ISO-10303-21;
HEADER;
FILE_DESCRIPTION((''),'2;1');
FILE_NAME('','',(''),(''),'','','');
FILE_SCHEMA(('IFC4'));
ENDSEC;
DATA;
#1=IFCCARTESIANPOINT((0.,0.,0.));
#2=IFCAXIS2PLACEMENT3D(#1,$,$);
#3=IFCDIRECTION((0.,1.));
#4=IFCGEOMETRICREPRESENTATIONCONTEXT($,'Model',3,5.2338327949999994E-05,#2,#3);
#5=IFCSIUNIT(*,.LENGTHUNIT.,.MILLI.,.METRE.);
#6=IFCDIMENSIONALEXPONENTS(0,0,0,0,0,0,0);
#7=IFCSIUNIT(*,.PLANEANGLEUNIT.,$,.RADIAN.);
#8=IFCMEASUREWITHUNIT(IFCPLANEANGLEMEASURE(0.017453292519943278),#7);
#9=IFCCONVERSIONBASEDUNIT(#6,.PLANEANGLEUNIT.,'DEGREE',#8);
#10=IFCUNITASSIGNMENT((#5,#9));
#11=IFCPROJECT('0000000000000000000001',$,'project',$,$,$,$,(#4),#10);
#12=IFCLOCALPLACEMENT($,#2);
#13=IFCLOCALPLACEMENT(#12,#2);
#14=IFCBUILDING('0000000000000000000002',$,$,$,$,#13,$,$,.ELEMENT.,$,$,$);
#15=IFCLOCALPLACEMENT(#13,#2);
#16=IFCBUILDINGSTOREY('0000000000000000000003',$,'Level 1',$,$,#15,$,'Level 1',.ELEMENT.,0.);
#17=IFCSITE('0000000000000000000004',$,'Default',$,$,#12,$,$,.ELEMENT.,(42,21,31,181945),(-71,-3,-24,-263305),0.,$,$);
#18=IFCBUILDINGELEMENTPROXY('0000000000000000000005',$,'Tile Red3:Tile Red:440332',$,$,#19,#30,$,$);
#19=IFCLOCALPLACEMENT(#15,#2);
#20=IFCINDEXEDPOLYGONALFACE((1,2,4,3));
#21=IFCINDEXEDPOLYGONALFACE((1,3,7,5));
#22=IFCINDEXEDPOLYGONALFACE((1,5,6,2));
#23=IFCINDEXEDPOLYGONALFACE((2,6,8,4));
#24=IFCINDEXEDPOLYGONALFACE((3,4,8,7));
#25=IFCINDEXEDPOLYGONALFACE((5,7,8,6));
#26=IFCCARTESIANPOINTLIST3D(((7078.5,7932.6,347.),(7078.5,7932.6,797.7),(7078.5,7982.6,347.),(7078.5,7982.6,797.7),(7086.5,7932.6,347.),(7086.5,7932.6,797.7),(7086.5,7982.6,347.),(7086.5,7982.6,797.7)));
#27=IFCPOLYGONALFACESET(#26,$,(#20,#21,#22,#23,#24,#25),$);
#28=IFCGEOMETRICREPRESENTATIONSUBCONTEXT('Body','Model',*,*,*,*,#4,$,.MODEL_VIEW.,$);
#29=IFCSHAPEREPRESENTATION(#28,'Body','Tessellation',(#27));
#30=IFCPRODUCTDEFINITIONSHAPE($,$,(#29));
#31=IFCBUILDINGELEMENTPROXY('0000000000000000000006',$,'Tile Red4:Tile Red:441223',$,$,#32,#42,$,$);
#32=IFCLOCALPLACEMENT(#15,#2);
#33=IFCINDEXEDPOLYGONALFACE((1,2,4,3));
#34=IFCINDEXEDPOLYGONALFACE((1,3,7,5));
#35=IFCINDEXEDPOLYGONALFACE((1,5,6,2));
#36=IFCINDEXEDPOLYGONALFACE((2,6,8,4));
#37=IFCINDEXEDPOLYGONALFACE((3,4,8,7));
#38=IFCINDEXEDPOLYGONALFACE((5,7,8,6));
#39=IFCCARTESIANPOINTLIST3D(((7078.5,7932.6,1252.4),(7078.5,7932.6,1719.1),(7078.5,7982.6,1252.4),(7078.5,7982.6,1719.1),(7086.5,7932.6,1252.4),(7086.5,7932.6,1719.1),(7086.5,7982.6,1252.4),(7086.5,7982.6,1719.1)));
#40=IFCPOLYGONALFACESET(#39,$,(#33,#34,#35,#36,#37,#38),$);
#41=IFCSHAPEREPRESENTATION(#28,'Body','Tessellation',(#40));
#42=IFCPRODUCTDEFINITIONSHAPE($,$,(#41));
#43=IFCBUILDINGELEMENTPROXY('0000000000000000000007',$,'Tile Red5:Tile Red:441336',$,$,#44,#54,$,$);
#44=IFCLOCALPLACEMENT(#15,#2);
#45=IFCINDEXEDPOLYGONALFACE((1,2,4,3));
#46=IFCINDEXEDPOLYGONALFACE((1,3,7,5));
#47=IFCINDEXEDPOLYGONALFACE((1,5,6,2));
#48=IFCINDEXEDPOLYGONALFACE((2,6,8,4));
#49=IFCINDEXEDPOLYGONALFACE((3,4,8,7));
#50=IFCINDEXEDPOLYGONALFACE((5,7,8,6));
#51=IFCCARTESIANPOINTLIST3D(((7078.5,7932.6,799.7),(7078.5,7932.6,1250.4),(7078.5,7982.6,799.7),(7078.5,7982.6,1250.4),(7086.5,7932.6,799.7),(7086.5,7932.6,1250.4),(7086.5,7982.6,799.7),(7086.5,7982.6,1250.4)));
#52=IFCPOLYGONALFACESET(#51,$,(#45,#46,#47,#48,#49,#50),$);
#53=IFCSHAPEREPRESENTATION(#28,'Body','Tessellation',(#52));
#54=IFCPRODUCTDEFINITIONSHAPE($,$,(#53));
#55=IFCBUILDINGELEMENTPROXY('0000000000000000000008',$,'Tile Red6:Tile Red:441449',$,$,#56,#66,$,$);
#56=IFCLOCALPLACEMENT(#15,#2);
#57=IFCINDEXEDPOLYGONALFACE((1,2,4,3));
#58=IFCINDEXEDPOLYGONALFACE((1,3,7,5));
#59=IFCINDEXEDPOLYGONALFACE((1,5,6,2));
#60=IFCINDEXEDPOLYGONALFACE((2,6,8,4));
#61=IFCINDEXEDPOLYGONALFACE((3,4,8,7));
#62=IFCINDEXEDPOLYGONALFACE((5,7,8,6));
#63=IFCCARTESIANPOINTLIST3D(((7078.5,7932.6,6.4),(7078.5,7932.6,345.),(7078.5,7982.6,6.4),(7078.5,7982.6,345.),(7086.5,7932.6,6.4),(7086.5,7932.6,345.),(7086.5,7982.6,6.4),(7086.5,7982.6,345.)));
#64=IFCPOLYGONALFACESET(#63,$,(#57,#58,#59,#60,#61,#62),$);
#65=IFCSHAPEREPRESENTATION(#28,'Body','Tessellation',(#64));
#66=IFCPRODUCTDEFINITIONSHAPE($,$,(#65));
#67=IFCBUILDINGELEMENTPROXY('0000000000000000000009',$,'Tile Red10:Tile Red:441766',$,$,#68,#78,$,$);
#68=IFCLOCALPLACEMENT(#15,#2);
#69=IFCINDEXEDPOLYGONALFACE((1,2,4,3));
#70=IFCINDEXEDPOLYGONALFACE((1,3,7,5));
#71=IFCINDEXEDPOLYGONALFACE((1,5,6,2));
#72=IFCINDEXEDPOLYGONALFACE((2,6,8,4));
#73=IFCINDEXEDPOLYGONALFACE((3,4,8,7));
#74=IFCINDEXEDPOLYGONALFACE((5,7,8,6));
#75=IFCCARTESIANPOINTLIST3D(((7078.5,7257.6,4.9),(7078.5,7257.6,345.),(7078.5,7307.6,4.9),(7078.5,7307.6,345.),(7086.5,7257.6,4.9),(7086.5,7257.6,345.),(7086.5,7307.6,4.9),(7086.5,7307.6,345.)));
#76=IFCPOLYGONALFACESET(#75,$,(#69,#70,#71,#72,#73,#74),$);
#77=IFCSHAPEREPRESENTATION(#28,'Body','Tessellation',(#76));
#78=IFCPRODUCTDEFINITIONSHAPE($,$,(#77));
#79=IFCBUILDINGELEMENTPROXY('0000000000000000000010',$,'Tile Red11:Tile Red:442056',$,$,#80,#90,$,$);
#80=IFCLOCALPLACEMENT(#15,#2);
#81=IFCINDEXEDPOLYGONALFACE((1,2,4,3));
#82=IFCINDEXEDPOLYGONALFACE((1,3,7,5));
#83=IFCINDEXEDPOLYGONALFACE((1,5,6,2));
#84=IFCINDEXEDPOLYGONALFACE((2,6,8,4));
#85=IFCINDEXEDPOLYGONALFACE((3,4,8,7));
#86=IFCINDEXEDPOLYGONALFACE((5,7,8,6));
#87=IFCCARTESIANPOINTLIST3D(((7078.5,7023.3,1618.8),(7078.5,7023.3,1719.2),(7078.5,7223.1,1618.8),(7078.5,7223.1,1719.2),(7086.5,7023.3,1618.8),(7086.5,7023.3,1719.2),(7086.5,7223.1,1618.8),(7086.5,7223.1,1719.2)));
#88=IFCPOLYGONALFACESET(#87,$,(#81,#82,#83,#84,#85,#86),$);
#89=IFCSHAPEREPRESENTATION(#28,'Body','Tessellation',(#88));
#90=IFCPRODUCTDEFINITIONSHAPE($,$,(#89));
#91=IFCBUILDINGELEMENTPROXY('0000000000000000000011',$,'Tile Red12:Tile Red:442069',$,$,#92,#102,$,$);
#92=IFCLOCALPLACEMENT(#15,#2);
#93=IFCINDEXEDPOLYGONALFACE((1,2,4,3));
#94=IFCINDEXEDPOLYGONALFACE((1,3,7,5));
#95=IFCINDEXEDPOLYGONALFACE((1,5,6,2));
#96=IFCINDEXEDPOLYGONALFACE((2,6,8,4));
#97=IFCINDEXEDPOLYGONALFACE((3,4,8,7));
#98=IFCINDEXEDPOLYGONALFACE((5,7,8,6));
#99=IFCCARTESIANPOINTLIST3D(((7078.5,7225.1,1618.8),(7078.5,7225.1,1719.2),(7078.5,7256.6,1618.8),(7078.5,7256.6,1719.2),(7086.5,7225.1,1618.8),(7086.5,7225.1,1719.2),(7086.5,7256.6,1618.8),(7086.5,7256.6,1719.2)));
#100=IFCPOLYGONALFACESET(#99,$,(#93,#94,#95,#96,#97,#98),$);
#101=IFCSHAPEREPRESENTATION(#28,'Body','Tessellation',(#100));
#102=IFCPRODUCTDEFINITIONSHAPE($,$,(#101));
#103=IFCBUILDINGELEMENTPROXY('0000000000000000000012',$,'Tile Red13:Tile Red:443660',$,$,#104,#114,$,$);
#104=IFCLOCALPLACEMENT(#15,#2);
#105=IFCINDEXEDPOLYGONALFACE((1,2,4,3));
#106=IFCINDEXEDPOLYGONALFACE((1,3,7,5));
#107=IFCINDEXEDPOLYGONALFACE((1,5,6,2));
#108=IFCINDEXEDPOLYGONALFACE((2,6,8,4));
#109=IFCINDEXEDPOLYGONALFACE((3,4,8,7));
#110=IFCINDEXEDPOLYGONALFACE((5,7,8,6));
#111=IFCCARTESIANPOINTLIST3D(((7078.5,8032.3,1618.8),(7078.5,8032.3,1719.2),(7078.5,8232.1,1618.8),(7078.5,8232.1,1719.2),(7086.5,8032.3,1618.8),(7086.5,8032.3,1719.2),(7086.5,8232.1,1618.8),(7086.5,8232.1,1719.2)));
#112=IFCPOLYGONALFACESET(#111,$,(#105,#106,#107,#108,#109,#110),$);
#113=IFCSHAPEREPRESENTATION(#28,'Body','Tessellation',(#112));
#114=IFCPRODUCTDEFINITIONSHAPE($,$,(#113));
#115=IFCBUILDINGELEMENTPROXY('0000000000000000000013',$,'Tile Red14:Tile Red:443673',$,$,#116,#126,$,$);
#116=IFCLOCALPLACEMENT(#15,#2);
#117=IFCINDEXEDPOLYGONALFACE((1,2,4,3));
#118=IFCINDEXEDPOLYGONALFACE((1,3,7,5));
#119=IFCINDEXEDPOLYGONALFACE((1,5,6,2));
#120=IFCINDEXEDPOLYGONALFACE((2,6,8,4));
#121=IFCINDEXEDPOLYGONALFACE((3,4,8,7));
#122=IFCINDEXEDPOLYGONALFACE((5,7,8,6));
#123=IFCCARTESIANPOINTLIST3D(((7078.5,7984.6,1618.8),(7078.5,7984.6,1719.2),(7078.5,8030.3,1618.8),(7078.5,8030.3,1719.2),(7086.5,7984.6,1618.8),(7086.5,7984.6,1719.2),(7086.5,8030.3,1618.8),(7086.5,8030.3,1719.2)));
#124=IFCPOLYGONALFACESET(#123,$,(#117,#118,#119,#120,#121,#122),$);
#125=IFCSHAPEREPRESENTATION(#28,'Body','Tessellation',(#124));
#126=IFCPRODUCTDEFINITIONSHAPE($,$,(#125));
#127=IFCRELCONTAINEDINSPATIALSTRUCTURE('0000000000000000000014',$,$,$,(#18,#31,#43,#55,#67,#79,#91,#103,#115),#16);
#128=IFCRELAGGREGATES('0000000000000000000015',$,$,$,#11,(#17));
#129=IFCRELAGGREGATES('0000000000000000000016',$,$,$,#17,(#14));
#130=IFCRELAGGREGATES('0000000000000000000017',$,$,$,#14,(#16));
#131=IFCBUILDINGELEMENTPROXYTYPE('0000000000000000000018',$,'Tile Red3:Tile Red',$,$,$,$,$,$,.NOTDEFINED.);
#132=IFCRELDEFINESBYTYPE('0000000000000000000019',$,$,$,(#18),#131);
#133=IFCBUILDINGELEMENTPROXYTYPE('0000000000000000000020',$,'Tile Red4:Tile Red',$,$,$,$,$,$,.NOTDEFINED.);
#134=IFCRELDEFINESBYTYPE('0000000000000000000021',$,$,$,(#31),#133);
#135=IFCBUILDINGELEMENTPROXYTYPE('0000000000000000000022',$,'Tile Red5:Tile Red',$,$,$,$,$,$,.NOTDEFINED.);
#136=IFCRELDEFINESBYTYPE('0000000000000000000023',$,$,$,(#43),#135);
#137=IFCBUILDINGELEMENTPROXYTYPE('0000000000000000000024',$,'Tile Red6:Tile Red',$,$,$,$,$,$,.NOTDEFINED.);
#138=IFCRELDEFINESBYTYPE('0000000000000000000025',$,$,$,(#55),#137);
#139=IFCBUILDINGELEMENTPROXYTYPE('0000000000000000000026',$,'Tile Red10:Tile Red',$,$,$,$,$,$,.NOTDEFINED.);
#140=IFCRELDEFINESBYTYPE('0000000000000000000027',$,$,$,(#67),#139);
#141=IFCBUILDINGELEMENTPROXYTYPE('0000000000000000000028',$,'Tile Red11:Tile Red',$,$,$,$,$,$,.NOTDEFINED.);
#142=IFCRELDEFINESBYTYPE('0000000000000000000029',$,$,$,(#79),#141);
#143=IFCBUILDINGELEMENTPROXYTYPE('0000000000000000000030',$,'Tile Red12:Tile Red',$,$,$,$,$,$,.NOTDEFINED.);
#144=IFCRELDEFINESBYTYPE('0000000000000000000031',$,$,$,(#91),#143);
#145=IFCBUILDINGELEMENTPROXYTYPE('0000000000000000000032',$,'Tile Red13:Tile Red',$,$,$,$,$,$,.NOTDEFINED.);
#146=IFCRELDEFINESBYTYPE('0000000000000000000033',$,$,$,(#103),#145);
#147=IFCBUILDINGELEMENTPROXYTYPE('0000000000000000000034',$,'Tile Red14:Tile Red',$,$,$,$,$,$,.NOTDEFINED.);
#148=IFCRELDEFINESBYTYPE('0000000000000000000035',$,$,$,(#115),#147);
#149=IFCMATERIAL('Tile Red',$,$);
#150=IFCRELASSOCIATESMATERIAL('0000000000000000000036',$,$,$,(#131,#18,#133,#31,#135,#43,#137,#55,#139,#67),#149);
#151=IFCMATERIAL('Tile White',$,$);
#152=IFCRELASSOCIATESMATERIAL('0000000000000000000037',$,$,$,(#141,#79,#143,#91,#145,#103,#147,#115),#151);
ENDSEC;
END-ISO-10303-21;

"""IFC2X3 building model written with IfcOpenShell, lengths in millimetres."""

from ifc_helpers import new_model, entity, si_unit, converted_unit, direction, frame, frame_2d, origin, origin_2d_with_axis, place, context, subcontext, project, spatial, rectangle, extrude, source, transform, mapped, material, type_object, type_shapes, element, save


model = new_model("IFC2X3")

# Units and contexts
model_context = context("Model", 3, precision=5.2338327949999994e-05, world=origin(), true_north=direction((0.0, 1.0)))
body_context = subcontext(model_context, "Body", "Model", "MODEL_VIEW")
ifc_project = project(units=[si_unit("LENGTHUNIT", "METRE", prefix="MILLI"), converted_unit("PLANEANGLEUNIT", "DEGREE", entity("IfcPlaneAngleMeasure", 0.017453292519943278), si_unit("PLANEANGLEUNIT", "RADIAN"), dimensions=[0, 0, 0, 0, 0, 0, 0])], contexts=[model_context])

# Site, building, storey
site_placement = place(None, origin())
site = spatial("IfcSite", under=ifc_project, at=site_placement, Name="Default", CompositionType="ELEMENT", RefLatitude=(42, 21, 31, 181945), RefLongitude=(-71, -3, -24, -263305), RefElevation=0.0)
building_placement = place(site_placement, origin())
building = spatial("IfcBuilding", under=site, at=building_placement, CompositionType="ELEMENT")
storey_placement = place(building_placement, origin())
storey = spatial("IfcBuildingStorey", under=building, at=storey_placement, Name="Level 1", LongName="Level 1", CompositionType="ELEMENT", Elevation=0.0)

# Building element proxies
ifc_material_1 = material(Name="Tile Red")
building_element_proxy_type_1 = type_object("IfcBuildingElementProxyType", Name="Tile Red3:Tile Red", PredefinedType="NOTDEFINED", material=ifc_material_1)
shared_shape_1 = source(origin(), body_context, "Body", "SweptSolid", [
    extrude(rectangle(XDim=8.0, YDim=50.0, at=origin_2d_with_axis()), frame((7082.5, 7957.6, 347.0)), (0.0, 0.0, 1.0), 450.7),
])
type_shapes(building_element_proxy_type_1, [shared_shape_1])
proxy_1_placement = place(storey_placement, origin())
element("IfcBuildingElementProxy", 1, at=proxy_1_placement, inside=storey, type_object=building_element_proxy_type_1, material=ifc_material_1, Name="Tile Red3:Tile Red:440332", context=body_context, shape_type="MappedRepresentation", body=[
    mapped(shared_shape_1, transform((0.0, 0.0, 0.0), scale=1.0)),
])
building_element_proxy_type_2 = type_object("IfcBuildingElementProxyType", Name="Tile Red4:Tile Red", PredefinedType="NOTDEFINED", material=ifc_material_1)
shared_shape_2 = source(origin(), body_context, "Body", "SweptSolid", [
    extrude(rectangle(XDim=8.0, YDim=50.0, at=origin_2d_with_axis()), frame((7082.5, 7957.6, 1252.4)), (0.0, 0.0, 1.0), 466.6),
])
type_shapes(building_element_proxy_type_2, [shared_shape_2])
proxy_2_placement = place(storey_placement, origin())
element("IfcBuildingElementProxy", 2, at=proxy_2_placement, inside=storey, type_object=building_element_proxy_type_2, material=ifc_material_1, Name="Tile Red4:Tile Red:441223", context=body_context, shape_type="MappedRepresentation", body=[
    mapped(shared_shape_2, transform((0.0, 0.0, 0.0), scale=1.0)),
])
building_element_proxy_type_3 = type_object("IfcBuildingElementProxyType", Name="Tile Red5:Tile Red", PredefinedType="NOTDEFINED", material=ifc_material_1)
shared_shape_3 = source(origin(), body_context, "Body", "SweptSolid", [
    extrude(rectangle(XDim=8.0, YDim=50.0, at=origin_2d_with_axis()), frame((7082.5, 7957.6, 799.7)), (0.0, 0.0, 1.0), 450.7),
])
type_shapes(building_element_proxy_type_3, [shared_shape_3])
proxy_3_placement = place(storey_placement, origin())
element("IfcBuildingElementProxy", 3, at=proxy_3_placement, inside=storey, type_object=building_element_proxy_type_3, material=ifc_material_1, Name="Tile Red5:Tile Red:441336", context=body_context, shape_type="MappedRepresentation", body=[
    mapped(shared_shape_3, transform((0.0, 0.0, 0.0), scale=1.0)),
])
building_element_proxy_type_4 = type_object("IfcBuildingElementProxyType", Name="Tile Red6:Tile Red", PredefinedType="NOTDEFINED", material=ifc_material_1)
shared_shape_4 = source(origin(), body_context, "Body", "SweptSolid", [
    extrude(rectangle(XDim=8.0, YDim=50.0, at=origin_2d_with_axis()), frame((7082.5, 7957.6, 6.4)), (0.0, 0.0, 1.0), 338.6),
])
type_shapes(building_element_proxy_type_4, [shared_shape_4])
proxy_4_placement = place(storey_placement, origin())
element("IfcBuildingElementProxy", 4, at=proxy_4_placement, inside=storey, type_object=building_element_proxy_type_4, material=ifc_material_1, Name="Tile Red6:Tile Red:441449", context=body_context, shape_type="MappedRepresentation", body=[
    mapped(shared_shape_4, transform((0.0, 0.0, 0.0), scale=1.0)),
])
building_element_proxy_type_5 = type_object("IfcBuildingElementProxyType", Name="Tile Red10:Tile Red", PredefinedType="NOTDEFINED", material=ifc_material_1)
shared_shape_5 = source(origin(), body_context, "Body", "SweptSolid", [
    extrude(rectangle(XDim=8.0, YDim=50.0, at=origin_2d_with_axis()), frame((7082.5, 7282.6, 4.9)), (0.0, 0.0, 1.0), 340.1),
])
type_shapes(building_element_proxy_type_5, [shared_shape_5])
proxy_5_placement = place(storey_placement, origin())
element("IfcBuildingElementProxy", 5, at=proxy_5_placement, inside=storey, type_object=building_element_proxy_type_5, material=ifc_material_1, Name="Tile Red10:Tile Red:441766", context=body_context, shape_type="MappedRepresentation", body=[
    mapped(shared_shape_5, transform((0.0, 0.0, 0.0), scale=1.0)),
])
ifc_material_2 = material(Name="Tile White")
building_element_proxy_type_6 = type_object("IfcBuildingElementProxyType", Name="Tile Red11:Tile Red", PredefinedType="NOTDEFINED", material=ifc_material_2)
shared_shape_6 = source(origin(), body_context, "Body", "SweptSolid", [
    extrude(rectangle(XDim=8.0, YDim=199.8, at=origin_2d_with_axis()), frame((7082.5, 7123.2, 1618.8)), (0.0, 0.0, 1.0), 100.4),
])
type_shapes(building_element_proxy_type_6, [shared_shape_6])
proxy_6_placement = place(storey_placement, origin())
element("IfcBuildingElementProxy", 6, at=proxy_6_placement, inside=storey, type_object=building_element_proxy_type_6, material=ifc_material_2, Name="Tile Red11:Tile Red:442056", context=body_context, shape_type="MappedRepresentation", body=[
    mapped(shared_shape_6, transform((0.0, 0.0, 0.0), scale=1.0)),
])
building_element_proxy_type_7 = type_object("IfcBuildingElementProxyType", Name="Tile Red12:Tile Red", PredefinedType="NOTDEFINED", material=ifc_material_2)
shared_shape_7 = source(origin(), body_context, "Body", "SweptSolid", [
    extrude(rectangle(XDim=8.0, YDim=31.5, at=frame_2d((0.0, 0.0), x_axis=(1.0, 0.0))), frame((7082.5, 7240.9, 1618.8)), (0.0, 0.0, 1.0), 100.4),
])
type_shapes(building_element_proxy_type_7, [shared_shape_7])
proxy_7_placement = place(storey_placement, origin())
element("IfcBuildingElementProxy", 7, at=proxy_7_placement, inside=storey, type_object=building_element_proxy_type_7, material=ifc_material_2, Name="Tile Red12:Tile Red:442069", context=body_context, shape_type="MappedRepresentation", body=[
    mapped(shared_shape_7, transform((0.0, 0.0, 0.0), scale=1.0)),
])
building_element_proxy_type_8 = type_object("IfcBuildingElementProxyType", Name="Tile Red13:Tile Red", PredefinedType="NOTDEFINED", material=ifc_material_2)
shared_shape_8 = source(origin(), body_context, "Body", "SweptSolid", [
    extrude(rectangle(XDim=8.0, YDim=199.8, at=origin_2d_with_axis()), frame((7082.5, 8132.2, 1618.8)), (0.0, 0.0, 1.0), 100.4),
])
type_shapes(building_element_proxy_type_8, [shared_shape_8])
proxy_8_placement = place(storey_placement, origin())
element("IfcBuildingElementProxy", 8, at=proxy_8_placement, inside=storey, type_object=building_element_proxy_type_8, material=ifc_material_2, Name="Tile Red13:Tile Red:443660", context=body_context, shape_type="MappedRepresentation", body=[
    mapped(shared_shape_8, transform((0.0, 0.0, 0.0), scale=1.0)),
])
building_element_proxy_type_9 = type_object("IfcBuildingElementProxyType", Name="Tile Red14:Tile Red", PredefinedType="NOTDEFINED", material=ifc_material_2)
shared_shape_9 = source(origin(), body_context, "Body", "SweptSolid", [
    extrude(rectangle(XDim=8.0, YDim=45.7, at=frame_2d((0.0, 0.0), x_axis=(1.0, 0.0))), frame((7082.5, 8007.5, 1618.8)), (0.0, 0.0, 1.0), 100.4),
])
type_shapes(building_element_proxy_type_9, [shared_shape_9])
proxy_9_placement = place(storey_placement, origin())
element("IfcBuildingElementProxy", 9, at=proxy_9_placement, inside=storey, type_object=building_element_proxy_type_9, material=ifc_material_2, Name="Tile Red14:Tile Red:443673", context=body_context, shape_type="MappedRepresentation", body=[
    mapped(shared_shape_9, transform((0.0, 0.0, 0.0), scale=1.0)),
])

save(model, "model.ifc")
